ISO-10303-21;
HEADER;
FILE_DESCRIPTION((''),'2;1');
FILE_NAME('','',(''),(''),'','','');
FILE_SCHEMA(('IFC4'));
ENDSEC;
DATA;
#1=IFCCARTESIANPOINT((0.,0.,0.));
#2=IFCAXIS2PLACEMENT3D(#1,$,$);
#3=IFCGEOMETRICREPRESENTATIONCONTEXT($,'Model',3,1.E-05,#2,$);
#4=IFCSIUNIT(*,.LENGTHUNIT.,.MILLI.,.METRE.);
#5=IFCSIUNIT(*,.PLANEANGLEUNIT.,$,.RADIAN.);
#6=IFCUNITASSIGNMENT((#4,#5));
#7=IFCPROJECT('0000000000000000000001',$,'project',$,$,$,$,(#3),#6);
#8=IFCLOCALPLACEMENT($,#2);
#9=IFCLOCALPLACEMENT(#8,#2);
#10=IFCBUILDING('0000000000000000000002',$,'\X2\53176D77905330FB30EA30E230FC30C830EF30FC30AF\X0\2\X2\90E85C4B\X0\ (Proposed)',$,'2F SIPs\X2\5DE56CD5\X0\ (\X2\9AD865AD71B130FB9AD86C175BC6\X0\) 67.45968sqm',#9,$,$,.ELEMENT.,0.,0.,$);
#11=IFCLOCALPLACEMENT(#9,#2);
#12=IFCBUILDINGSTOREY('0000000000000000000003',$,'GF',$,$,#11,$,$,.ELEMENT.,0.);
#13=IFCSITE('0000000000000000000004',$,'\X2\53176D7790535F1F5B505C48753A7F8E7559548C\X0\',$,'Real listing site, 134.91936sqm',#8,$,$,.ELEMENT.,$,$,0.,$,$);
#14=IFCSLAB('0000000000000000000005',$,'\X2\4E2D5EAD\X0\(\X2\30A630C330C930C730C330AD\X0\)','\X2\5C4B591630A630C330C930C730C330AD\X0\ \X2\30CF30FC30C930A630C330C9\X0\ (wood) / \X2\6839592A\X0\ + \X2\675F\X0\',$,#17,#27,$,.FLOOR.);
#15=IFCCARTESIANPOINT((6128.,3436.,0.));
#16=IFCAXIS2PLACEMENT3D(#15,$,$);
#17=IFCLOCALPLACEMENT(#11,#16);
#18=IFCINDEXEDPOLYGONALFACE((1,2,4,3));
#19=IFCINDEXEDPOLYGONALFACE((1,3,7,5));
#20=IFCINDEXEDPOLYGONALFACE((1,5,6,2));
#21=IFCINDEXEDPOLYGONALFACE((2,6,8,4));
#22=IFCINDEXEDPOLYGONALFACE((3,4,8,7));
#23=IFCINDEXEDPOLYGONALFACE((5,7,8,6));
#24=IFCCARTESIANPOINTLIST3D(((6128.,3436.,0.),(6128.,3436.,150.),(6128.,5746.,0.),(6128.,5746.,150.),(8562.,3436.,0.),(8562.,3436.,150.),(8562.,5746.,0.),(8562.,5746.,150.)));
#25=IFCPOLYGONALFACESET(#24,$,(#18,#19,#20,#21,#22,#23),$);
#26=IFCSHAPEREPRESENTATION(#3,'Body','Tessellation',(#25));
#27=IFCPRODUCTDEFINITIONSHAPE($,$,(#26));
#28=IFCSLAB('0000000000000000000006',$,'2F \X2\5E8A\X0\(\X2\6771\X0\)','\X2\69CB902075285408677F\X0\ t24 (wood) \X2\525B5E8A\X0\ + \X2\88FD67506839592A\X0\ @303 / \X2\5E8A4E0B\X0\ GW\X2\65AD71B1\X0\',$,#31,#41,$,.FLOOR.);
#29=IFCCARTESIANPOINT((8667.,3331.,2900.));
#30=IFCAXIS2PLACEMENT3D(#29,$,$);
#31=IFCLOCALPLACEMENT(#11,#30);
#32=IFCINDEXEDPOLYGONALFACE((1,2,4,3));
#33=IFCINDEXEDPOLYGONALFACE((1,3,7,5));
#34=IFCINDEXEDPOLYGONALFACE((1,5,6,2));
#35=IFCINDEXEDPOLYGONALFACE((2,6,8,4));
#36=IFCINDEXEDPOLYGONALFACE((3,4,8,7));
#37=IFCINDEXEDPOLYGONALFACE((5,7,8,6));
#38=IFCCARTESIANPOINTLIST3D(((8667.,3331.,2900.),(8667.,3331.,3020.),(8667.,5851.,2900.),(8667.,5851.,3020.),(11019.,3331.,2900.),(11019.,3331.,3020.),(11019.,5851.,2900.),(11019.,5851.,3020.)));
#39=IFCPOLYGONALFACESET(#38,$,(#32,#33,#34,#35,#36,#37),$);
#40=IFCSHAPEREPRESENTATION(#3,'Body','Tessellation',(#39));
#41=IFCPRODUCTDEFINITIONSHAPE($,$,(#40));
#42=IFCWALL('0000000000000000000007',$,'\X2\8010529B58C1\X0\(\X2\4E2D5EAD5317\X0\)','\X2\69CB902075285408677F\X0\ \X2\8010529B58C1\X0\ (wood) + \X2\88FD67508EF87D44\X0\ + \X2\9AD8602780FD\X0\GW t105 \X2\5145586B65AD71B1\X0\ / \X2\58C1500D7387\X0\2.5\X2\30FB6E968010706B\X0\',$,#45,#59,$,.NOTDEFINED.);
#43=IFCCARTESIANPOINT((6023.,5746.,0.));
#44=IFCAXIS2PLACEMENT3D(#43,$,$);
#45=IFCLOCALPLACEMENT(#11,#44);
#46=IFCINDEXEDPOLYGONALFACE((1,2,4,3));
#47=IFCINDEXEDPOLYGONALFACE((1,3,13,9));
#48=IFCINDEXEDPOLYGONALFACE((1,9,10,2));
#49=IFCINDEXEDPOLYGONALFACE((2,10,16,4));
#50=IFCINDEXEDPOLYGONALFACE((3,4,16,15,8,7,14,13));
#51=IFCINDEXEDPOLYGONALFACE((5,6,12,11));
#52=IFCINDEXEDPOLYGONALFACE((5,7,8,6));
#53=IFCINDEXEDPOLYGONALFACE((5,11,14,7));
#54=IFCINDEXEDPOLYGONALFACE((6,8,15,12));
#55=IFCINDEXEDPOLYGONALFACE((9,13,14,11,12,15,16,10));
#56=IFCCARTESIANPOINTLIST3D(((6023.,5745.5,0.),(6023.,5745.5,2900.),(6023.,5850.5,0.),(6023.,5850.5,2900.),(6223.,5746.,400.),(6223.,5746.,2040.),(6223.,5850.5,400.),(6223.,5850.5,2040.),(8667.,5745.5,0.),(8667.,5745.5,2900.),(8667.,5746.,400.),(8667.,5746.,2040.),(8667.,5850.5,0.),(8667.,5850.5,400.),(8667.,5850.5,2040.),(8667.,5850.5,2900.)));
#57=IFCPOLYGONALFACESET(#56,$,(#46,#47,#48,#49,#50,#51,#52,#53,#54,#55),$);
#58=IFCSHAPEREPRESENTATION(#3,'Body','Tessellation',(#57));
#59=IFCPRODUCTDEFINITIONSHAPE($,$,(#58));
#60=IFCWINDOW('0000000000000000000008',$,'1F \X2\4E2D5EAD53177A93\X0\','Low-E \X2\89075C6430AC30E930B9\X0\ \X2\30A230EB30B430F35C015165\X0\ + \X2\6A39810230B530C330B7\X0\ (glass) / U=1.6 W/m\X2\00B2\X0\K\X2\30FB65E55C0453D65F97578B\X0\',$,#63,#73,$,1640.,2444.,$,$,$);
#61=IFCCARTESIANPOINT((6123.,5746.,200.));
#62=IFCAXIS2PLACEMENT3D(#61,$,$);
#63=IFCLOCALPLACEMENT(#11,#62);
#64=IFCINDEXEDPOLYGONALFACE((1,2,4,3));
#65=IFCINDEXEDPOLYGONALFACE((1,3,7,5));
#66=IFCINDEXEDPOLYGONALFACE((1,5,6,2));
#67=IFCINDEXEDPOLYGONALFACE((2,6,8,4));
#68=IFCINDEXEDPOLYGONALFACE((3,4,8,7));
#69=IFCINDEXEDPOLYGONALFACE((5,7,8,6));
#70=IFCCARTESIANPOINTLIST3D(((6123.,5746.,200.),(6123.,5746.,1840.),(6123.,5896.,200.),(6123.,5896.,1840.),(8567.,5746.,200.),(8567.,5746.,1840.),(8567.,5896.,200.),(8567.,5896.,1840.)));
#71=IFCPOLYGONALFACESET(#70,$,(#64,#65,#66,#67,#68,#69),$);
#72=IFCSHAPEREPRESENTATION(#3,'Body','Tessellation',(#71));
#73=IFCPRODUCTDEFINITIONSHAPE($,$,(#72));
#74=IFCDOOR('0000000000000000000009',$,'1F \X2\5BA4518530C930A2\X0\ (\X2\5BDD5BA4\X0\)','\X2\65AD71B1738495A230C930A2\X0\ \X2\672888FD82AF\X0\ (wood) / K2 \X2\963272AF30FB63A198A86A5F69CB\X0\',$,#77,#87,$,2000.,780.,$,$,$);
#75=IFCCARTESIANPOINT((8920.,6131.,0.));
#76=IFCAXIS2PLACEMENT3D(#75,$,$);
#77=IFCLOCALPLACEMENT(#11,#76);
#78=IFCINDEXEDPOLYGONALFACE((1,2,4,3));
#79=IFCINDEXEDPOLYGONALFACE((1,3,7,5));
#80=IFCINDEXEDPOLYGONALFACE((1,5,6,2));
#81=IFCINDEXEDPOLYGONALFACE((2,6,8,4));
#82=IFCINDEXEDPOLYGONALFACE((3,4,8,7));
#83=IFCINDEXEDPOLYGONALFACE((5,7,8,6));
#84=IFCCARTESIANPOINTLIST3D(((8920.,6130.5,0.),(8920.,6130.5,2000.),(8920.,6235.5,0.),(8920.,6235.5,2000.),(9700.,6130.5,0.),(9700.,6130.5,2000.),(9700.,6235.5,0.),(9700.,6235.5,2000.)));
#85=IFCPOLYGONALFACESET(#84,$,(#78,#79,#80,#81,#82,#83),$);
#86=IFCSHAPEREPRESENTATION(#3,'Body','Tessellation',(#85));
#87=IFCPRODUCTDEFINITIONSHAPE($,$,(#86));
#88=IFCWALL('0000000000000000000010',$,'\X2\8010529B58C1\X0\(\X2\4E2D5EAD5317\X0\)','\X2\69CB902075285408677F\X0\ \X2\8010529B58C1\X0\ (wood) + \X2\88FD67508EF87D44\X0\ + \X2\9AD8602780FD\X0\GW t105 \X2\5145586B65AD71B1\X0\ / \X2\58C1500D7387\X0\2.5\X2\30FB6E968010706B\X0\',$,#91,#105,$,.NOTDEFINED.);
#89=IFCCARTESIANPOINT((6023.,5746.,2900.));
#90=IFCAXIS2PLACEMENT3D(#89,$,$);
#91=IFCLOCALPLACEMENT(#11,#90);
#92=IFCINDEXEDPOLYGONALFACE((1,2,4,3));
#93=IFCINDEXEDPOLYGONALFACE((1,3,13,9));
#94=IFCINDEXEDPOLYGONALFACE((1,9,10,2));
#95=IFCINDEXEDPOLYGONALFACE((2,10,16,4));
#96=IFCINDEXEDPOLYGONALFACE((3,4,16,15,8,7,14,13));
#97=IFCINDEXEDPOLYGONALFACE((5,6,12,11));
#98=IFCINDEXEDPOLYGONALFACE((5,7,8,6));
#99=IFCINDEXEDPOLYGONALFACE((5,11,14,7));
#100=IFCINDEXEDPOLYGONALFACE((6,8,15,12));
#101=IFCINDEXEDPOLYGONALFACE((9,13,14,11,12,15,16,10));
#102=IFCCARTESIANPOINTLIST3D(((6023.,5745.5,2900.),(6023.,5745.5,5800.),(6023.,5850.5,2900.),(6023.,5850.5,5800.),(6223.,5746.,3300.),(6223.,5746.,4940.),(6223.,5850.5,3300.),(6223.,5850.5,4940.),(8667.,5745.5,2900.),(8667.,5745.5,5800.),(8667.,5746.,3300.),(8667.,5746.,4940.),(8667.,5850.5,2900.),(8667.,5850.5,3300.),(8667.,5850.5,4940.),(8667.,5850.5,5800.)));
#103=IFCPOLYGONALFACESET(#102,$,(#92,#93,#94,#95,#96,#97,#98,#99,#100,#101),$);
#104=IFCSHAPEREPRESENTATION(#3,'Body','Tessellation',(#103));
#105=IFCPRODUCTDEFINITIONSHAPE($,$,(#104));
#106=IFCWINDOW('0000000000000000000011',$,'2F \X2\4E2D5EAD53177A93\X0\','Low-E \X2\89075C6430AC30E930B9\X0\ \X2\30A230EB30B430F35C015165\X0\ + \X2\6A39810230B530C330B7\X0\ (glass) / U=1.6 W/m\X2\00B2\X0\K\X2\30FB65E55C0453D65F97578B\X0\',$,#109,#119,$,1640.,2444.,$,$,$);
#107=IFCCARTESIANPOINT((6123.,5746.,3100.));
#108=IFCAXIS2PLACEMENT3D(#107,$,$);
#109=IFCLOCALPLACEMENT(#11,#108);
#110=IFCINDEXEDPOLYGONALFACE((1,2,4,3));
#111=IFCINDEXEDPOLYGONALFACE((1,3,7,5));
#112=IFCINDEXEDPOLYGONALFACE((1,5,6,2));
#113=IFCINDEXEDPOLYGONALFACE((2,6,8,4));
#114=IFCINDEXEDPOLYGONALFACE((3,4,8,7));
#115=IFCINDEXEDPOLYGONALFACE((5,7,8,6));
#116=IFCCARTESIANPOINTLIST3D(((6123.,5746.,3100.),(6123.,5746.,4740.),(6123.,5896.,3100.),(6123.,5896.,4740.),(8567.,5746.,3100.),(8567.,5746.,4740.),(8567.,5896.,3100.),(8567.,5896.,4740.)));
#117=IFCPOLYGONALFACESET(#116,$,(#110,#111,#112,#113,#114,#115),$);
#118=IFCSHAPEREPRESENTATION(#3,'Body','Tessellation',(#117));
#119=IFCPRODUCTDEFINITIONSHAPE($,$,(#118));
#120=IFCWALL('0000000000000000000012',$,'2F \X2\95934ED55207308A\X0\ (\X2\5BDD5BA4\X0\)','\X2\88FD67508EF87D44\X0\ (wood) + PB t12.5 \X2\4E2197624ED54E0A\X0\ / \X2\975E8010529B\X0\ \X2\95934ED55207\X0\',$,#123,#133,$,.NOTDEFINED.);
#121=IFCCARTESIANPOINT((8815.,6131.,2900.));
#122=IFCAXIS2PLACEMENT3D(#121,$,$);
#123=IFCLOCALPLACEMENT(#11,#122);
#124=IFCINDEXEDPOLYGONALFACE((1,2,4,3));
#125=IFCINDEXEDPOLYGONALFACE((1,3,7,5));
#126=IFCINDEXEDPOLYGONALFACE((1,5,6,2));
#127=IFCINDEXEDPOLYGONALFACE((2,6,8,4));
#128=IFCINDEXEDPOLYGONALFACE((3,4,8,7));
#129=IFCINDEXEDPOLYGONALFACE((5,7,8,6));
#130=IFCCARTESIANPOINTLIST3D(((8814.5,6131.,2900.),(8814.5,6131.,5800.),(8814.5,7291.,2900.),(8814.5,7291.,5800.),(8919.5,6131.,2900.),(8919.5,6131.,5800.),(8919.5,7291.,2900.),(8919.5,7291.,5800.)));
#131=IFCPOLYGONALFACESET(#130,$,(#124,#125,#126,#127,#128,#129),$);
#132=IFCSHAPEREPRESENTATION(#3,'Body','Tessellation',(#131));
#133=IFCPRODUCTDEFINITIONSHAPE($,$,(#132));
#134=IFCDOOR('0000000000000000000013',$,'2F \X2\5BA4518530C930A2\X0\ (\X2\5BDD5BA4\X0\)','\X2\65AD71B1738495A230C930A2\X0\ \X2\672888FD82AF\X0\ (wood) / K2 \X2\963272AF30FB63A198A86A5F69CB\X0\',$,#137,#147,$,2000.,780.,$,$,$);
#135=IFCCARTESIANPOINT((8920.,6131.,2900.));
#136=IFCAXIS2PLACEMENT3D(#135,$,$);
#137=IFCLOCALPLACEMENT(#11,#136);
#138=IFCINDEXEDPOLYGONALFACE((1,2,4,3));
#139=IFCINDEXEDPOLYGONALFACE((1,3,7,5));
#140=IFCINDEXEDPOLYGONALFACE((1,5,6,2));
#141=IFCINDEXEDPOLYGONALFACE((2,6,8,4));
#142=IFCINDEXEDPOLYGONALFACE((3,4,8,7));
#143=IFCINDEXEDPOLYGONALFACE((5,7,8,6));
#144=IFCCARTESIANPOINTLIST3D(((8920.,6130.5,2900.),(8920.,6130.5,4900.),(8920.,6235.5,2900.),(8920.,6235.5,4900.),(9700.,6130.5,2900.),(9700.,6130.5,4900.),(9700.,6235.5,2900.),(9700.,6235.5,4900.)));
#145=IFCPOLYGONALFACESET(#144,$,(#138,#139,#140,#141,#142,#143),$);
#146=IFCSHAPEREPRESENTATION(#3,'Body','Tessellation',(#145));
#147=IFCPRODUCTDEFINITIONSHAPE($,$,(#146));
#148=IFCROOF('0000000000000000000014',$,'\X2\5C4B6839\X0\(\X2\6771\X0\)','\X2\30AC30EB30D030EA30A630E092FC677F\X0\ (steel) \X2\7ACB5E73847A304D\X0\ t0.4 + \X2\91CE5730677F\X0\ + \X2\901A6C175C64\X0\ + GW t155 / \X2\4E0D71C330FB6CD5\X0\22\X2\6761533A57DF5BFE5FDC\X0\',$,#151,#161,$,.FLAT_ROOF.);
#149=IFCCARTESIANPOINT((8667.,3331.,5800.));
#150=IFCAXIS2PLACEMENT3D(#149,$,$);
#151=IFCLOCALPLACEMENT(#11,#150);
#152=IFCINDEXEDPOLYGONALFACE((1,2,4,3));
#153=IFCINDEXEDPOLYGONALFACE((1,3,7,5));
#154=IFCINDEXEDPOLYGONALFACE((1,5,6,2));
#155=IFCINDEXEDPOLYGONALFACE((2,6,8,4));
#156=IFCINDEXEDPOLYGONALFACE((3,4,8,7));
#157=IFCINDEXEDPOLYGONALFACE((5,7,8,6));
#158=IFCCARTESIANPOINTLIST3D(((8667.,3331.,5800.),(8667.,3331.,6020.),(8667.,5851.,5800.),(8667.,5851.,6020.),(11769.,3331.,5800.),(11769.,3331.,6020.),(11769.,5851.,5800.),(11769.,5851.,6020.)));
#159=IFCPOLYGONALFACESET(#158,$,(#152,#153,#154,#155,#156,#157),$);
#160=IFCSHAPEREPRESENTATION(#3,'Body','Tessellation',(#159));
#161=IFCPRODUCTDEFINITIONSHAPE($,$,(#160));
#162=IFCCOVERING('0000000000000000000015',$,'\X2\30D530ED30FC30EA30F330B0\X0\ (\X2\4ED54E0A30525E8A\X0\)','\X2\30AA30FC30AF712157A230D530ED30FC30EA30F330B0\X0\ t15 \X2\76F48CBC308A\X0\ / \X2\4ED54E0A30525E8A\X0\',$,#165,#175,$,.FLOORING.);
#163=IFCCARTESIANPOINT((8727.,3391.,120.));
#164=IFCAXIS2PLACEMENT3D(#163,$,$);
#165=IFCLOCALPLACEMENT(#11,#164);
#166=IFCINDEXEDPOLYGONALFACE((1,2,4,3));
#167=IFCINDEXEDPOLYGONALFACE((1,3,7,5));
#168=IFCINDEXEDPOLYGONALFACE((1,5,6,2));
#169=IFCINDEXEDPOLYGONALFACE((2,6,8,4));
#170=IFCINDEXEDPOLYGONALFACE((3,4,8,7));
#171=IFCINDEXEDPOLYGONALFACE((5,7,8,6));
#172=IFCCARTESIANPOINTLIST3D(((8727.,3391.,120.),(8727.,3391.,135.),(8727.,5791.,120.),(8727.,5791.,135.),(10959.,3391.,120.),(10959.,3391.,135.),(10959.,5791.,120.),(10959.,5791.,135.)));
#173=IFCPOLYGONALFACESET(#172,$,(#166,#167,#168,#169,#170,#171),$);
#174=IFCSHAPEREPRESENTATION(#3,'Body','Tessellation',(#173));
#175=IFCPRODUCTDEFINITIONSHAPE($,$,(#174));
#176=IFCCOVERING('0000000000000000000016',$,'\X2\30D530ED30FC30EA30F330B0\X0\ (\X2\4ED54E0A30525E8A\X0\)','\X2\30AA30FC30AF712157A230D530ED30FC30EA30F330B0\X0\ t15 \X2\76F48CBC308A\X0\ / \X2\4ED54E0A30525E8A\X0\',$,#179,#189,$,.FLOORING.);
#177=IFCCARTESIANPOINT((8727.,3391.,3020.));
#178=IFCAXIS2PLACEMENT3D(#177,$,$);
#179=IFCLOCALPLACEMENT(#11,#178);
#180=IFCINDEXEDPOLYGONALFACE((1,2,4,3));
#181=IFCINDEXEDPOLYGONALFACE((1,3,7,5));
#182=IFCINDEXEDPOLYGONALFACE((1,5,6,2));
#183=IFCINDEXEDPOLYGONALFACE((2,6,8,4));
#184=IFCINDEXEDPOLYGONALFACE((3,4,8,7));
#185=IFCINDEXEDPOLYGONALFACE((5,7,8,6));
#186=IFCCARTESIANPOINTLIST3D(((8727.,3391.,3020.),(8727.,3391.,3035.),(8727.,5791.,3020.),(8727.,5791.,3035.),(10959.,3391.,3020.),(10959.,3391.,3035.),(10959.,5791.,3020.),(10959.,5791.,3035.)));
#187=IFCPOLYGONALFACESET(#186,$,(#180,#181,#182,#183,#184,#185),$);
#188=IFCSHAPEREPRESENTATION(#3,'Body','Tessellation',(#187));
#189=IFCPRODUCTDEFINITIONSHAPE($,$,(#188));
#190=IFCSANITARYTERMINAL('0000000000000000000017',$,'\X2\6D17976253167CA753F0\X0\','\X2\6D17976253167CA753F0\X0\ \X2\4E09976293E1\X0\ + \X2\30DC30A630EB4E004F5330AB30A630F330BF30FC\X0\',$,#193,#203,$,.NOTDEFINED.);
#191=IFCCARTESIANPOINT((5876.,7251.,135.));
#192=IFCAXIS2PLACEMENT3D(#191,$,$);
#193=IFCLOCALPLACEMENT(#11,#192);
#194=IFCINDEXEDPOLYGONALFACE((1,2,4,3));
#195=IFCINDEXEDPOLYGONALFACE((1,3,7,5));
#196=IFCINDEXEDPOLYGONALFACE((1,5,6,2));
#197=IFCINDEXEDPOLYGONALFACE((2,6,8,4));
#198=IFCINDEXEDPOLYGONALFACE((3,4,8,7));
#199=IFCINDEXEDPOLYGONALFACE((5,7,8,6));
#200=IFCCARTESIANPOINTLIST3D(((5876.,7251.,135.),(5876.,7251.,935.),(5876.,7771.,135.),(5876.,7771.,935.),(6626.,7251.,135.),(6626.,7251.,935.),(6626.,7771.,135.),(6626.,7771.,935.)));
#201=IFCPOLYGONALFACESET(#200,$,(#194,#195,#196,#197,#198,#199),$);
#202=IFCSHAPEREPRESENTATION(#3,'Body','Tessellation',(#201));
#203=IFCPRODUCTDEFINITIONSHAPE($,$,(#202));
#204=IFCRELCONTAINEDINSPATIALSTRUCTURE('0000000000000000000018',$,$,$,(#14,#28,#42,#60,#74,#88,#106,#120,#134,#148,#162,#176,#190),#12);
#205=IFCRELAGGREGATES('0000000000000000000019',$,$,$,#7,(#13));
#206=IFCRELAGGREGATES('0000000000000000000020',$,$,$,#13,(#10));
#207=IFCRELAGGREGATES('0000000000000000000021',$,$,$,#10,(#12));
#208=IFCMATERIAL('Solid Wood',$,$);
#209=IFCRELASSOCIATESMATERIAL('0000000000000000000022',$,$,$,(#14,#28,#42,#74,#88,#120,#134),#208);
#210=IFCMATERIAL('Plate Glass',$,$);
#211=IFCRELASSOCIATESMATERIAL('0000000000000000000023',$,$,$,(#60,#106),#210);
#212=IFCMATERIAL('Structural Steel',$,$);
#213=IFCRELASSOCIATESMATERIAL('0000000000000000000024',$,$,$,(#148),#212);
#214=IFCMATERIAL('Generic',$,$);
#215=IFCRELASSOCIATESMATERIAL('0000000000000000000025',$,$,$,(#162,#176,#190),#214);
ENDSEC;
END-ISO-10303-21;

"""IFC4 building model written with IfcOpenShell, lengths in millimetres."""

from ifc_helpers import new_model, si_unit, frame, frame_2d, origin, place, context, project, spatial, rectangle, extrude, material, element, fill, save


model = new_model("IFC4")

# Units and contexts
model_context = context("Model", 3, precision=1e-05, world=origin())
ifc_project = project(units=[si_unit("LENGTHUNIT", "METRE", prefix="MILLI"), si_unit("PLANEANGLEUNIT", "RADIAN")], contexts=[model_context])

# Site, building, storey
site_placement = place(None, origin())
site = spatial("IfcSite", under=ifc_project, at=site_placement, Name="北海道弟子屈町美留和", ObjectType="Real listing site, 134.91936sqm", CompositionType="ELEMENT", RefElevation=0.0)
building_placement = place(site_placement, origin())
building = spatial("IfcBuilding", under=site, at=building_placement, Name="北海道・リモートワーク2部屋 (Proposed)", ObjectType="2F SIPs工法 (高断熱・高気密) 67.45968sqm", CompositionType="ELEMENT", ElevationOfRefHeight=0.0, ElevationOfTerrain=0.0)
storey_placement = place(building_placement, origin())
storey = spatial("IfcBuildingStorey", under=building, at=storey_placement, Name="GF", CompositionType="ELEMENT", Elevation=0.0)

# Slabs
ifc_material_1 = material(Name="Solid Wood")
slab_1_placement = place(storey_placement, frame((6128.0, 3436.0, 0.0)))
element("IfcSlab", 1, at=slab_1_placement, inside=storey, material=ifc_material_1, Name="中庭(ウッドデッキ)", Description="屋外ウッドデッキ ハードウッド (wood) / 根太 + 束", PredefinedType="FLOOR", context=model_context, shape_type="SweptSolid", body=[
    extrude(rectangle(XDim=2434.0, YDim=2310.0, at=frame_2d((1217.0, 1155.0))), frame((6128.0, 3436.0, 0.0)), (0.0, 0.0, 1.0), 150.0),
])
slab_2_placement = place(storey_placement, frame((8667.0, 3331.0, 2900.0)))
element("IfcSlab", 2, at=slab_2_placement, inside=storey, material=ifc_material_1, Name="2F 床(東)", Description="構造用合板 t24 (wood) 剛床 + 製材根太 @303 / 床下 GW断熱", PredefinedType="FLOOR", context=model_context, shape_type="SweptSolid", body=[
    extrude(rectangle(XDim=2352.0, YDim=2520.0, at=frame_2d((1176.0, 1260.0))), frame((8667.0, 3331.0, 2900.0)), (0.0, 0.0, 1.0), 120.0),
])

# Wall, opening, window
wall_1_placement = place(storey_placement, frame((6023.0, 5746.0, 0.0)))
wall_1 = element("IfcWall", 3, at=wall_1_placement, inside=storey, material=ifc_material_1, Name="耐力壁(中庭北)", Description="構造用合板 耐力壁 (wood) + 製材軸組 + 高性能GW t105 充填断熱 / 壁倍率2.5・準耐火", PredefinedType="NOTDEFINED", context=model_context, shape_type="SweptSolid", body=[
    extrude(rectangle(XDim=2644.0, YDim=105.0, at=frame_2d((1322.0, 52.0))), frame((6023.0, 5746.0, 0.0)), (0.0, 0.0, 1.0), 2900.0),
])
opening_1_placement = place(storey_placement, frame((6123.0, 5746.0, 200.0)))
opening_1 = element("IfcOpeningElement", 4, at=opening_1_placement, cuts=wall_1, PredefinedType="NOTDEFINED", context=model_context, shape_type="SweptSolid", body=[
    extrude(rectangle(XDim=2444.0, YDim=150.0, at=frame_2d((1222.0, 75.0))), frame((6123.0, 5746.0, 200.0)), (0.0, 0.0, 1.0), 1640.0),
])
ifc_material_2 = material(Name="Plate Glass")
window_1_placement = place(storey_placement, frame((6123.0, 5746.0, 200.0)))
window_1 = element("IfcWindow", 5, at=window_1_placement, inside=storey, material=ifc_material_2, Name="1F 中庭北窓", Description="Low-E 複層ガラス アルゴン封入 + 樹脂サッシ (glass) / U=1.6 W/m²K・日射取得型", OverallHeight=1640.0, OverallWidth=2444.0, context=model_context, shape_type="SweptSolid", body=[
    extrude(rectangle(XDim=2444.0, YDim=150.0, at=frame_2d((1222.0, 75.0))), frame((6123.0, 5746.0, 200.0)), (0.0, 0.0, 1.0), 1640.0),
])
fill(opening_1, window_1)

# Door
door_1_placement = place(storey_placement, frame((8920.0, 6131.0, 0.0)))
element("IfcDoor", 6, at=door_1_placement, inside=storey, material=ifc_material_1, Name="1F 室内ドア (寝室)", Description="断熱玄関ドア 木製芯 (wood) / K2 防犯・採風機構", OverallHeight=2000.0, OverallWidth=780.0, context=model_context, shape_type="SweptSolid", body=[
    extrude(rectangle(XDim=780.0, YDim=105.0, at=frame_2d((390.0, 52.0))), frame((8920.0, 6131.0, 0.0)), (0.0, 0.0, 1.0), 2000.0),
])

# Wall, opening, window
wall_2_placement = place(storey_placement, frame((6023.0, 5746.0, 2900.0)))
wall_2 = element("IfcWall", 7, at=wall_2_placement, inside=storey, material=ifc_material_1, Name="耐力壁(中庭北)", Description="構造用合板 耐力壁 (wood) + 製材軸組 + 高性能GW t105 充填断熱 / 壁倍率2.5・準耐火", PredefinedType="NOTDEFINED", context=model_context, shape_type="SweptSolid", body=[
    extrude(rectangle(XDim=2644.0, YDim=105.0, at=frame_2d((1322.0, 52.0))), frame((6023.0, 5746.0, 2900.0)), (0.0, 0.0, 1.0), 2900.0),
])
opening_2_placement = place(storey_placement, frame((6123.0, 5746.0, 3100.0)))
opening_2 = element("IfcOpeningElement", 8, at=opening_2_placement, cuts=wall_2, PredefinedType="NOTDEFINED", context=model_context, shape_type="SweptSolid", body=[
    extrude(rectangle(XDim=2444.0, YDim=150.0, at=frame_2d((1222.0, 75.0))), frame((6123.0, 5746.0, 3100.0)), (0.0, 0.0, 1.0), 1640.0),
])
window_2_placement = place(storey_placement, frame((6123.0, 5746.0, 3100.0)))
window_2 = element("IfcWindow", 9, at=window_2_placement, inside=storey, material=ifc_material_2, Name="2F 中庭北窓", Description="Low-E 複層ガラス アルゴン封入 + 樹脂サッシ (glass) / U=1.6 W/m²K・日射取得型", OverallHeight=1640.0, OverallWidth=2444.0, context=model_context, shape_type="SweptSolid", body=[
    extrude(rectangle(XDim=2444.0, YDim=150.0, at=frame_2d((1222.0, 75.0))), frame((6123.0, 5746.0, 3100.0)), (0.0, 0.0, 1.0), 1640.0),
])
fill(opening_2, window_2)

# Wall
wall_3_placement = place(storey_placement, frame((8815.0, 6131.0, 2900.0)))
element("IfcWall", 10, at=wall_3_placement, inside=storey, material=ifc_material_1, Name="2F 間仕切り (寝室)", Description="製材軸組 (wood) + PB t12.5 両面仕上 / 非耐力 間仕切", PredefinedType="NOTDEFINED", context=model_context, shape_type="SweptSolid", body=[
    extrude(rectangle(XDim=105.0, YDim=1160.0, at=frame_2d((52.0, 580.0))), frame((8815.0, 6131.0, 2900.0)), (0.0, 0.0, 1.0), 2900.0),
])

# Door
door_2_placement = place(storey_placement, frame((8920.0, 6131.0, 2900.0)))
element("IfcDoor", 11, at=door_2_placement, inside=storey, material=ifc_material_1, Name="2F 室内ドア (寝室)", Description="断熱玄関ドア 木製芯 (wood) / K2 防犯・採風機構", OverallHeight=2000.0, OverallWidth=780.0, context=model_context, shape_type="SweptSolid", body=[
    extrude(rectangle(XDim=780.0, YDim=105.0, at=frame_2d((390.0, 52.0))), frame((8920.0, 6131.0, 2900.0)), (0.0, 0.0, 1.0), 2000.0),
])

# Roof
ifc_material_3 = material(Name="Structural Steel")
for number, where, name in (
    (12, (8667.0, 3331.0, 5800.0), "屋根(東)"),
):
    element("IfcRoof", number, at=place(storey_placement, frame(where)), inside=storey, material=ifc_material_3, Name=name, Description="ガルバリウム鋼板 (steel) 立平葺き t0.4 + 野地板 + 通気層 + GW t155 / 不燃・法22条区域対応", PredefinedType="FLAT_ROOF", context=model_context, shape_type="SweptSolid", body=[
        extrude(rectangle(XDim=3102.0, YDim=2520.0, at=frame_2d((1551.0, 1260.0))), frame((8667.0, 3331.0, 5800.0)), (0.0, 0.0, 1.0), 220.0),
    ])

# Coverings
ifc_material_4 = material(Name="Generic")
covering_1_placement = place(storey_placement, frame((8727.0, 3391.0, 120.0)))
element("IfcCovering", 13, at=covering_1_placement, inside=storey, material=ifc_material_4, Name="フローリング (仕上げ床)", Description="オーク無垢フローリング t15 直貼り / 仕上げ床", PredefinedType="FLOORING", context=model_context, shape_type="SweptSolid", body=[
    extrude(rectangle(XDim=2232.0, YDim=2400.0, at=frame_2d((1116.0, 1200.0))), frame((8727.0, 3391.0, 120.0)), (0.0, 0.0, 1.0), 15.0),
])
covering_2_placement = place(storey_placement, frame((8727.0, 3391.0, 3020.0)))
element("IfcCovering", 14, at=covering_2_placement, inside=storey, material=ifc_material_4, Name="フローリング (仕上げ床)", Description="オーク無垢フローリング t15 直貼り / 仕上げ床", PredefinedType="FLOORING", context=model_context, shape_type="SweptSolid", body=[
    extrude(rectangle(XDim=2232.0, YDim=2400.0, at=frame_2d((1116.0, 1200.0))), frame((8727.0, 3391.0, 3020.0)), (0.0, 0.0, 1.0), 15.0),
])

# Sanitary terminal
sanitary_terminal_1_placement = place(storey_placement, frame((5876.0, 7251.0, 135.0)))
element("IfcSanitaryTerminal", 15, at=sanitary_terminal_1_placement, inside=storey, material=ifc_material_4, Name="洗面化粧台", Description="洗面化粧台 三面鏡 + ボウル一体カウンター", PredefinedType="NOTDEFINED", context=model_context, shape_type="SweptSolid", body=[
    extrude(rectangle(XDim=750.0, YDim=520.0, at=frame_2d((375.0, 260.0))), frame((5876.0, 7251.0, 135.0)), (0.0, 0.0, 1.0), 800.0),
])

save(model, "model.ifc")
